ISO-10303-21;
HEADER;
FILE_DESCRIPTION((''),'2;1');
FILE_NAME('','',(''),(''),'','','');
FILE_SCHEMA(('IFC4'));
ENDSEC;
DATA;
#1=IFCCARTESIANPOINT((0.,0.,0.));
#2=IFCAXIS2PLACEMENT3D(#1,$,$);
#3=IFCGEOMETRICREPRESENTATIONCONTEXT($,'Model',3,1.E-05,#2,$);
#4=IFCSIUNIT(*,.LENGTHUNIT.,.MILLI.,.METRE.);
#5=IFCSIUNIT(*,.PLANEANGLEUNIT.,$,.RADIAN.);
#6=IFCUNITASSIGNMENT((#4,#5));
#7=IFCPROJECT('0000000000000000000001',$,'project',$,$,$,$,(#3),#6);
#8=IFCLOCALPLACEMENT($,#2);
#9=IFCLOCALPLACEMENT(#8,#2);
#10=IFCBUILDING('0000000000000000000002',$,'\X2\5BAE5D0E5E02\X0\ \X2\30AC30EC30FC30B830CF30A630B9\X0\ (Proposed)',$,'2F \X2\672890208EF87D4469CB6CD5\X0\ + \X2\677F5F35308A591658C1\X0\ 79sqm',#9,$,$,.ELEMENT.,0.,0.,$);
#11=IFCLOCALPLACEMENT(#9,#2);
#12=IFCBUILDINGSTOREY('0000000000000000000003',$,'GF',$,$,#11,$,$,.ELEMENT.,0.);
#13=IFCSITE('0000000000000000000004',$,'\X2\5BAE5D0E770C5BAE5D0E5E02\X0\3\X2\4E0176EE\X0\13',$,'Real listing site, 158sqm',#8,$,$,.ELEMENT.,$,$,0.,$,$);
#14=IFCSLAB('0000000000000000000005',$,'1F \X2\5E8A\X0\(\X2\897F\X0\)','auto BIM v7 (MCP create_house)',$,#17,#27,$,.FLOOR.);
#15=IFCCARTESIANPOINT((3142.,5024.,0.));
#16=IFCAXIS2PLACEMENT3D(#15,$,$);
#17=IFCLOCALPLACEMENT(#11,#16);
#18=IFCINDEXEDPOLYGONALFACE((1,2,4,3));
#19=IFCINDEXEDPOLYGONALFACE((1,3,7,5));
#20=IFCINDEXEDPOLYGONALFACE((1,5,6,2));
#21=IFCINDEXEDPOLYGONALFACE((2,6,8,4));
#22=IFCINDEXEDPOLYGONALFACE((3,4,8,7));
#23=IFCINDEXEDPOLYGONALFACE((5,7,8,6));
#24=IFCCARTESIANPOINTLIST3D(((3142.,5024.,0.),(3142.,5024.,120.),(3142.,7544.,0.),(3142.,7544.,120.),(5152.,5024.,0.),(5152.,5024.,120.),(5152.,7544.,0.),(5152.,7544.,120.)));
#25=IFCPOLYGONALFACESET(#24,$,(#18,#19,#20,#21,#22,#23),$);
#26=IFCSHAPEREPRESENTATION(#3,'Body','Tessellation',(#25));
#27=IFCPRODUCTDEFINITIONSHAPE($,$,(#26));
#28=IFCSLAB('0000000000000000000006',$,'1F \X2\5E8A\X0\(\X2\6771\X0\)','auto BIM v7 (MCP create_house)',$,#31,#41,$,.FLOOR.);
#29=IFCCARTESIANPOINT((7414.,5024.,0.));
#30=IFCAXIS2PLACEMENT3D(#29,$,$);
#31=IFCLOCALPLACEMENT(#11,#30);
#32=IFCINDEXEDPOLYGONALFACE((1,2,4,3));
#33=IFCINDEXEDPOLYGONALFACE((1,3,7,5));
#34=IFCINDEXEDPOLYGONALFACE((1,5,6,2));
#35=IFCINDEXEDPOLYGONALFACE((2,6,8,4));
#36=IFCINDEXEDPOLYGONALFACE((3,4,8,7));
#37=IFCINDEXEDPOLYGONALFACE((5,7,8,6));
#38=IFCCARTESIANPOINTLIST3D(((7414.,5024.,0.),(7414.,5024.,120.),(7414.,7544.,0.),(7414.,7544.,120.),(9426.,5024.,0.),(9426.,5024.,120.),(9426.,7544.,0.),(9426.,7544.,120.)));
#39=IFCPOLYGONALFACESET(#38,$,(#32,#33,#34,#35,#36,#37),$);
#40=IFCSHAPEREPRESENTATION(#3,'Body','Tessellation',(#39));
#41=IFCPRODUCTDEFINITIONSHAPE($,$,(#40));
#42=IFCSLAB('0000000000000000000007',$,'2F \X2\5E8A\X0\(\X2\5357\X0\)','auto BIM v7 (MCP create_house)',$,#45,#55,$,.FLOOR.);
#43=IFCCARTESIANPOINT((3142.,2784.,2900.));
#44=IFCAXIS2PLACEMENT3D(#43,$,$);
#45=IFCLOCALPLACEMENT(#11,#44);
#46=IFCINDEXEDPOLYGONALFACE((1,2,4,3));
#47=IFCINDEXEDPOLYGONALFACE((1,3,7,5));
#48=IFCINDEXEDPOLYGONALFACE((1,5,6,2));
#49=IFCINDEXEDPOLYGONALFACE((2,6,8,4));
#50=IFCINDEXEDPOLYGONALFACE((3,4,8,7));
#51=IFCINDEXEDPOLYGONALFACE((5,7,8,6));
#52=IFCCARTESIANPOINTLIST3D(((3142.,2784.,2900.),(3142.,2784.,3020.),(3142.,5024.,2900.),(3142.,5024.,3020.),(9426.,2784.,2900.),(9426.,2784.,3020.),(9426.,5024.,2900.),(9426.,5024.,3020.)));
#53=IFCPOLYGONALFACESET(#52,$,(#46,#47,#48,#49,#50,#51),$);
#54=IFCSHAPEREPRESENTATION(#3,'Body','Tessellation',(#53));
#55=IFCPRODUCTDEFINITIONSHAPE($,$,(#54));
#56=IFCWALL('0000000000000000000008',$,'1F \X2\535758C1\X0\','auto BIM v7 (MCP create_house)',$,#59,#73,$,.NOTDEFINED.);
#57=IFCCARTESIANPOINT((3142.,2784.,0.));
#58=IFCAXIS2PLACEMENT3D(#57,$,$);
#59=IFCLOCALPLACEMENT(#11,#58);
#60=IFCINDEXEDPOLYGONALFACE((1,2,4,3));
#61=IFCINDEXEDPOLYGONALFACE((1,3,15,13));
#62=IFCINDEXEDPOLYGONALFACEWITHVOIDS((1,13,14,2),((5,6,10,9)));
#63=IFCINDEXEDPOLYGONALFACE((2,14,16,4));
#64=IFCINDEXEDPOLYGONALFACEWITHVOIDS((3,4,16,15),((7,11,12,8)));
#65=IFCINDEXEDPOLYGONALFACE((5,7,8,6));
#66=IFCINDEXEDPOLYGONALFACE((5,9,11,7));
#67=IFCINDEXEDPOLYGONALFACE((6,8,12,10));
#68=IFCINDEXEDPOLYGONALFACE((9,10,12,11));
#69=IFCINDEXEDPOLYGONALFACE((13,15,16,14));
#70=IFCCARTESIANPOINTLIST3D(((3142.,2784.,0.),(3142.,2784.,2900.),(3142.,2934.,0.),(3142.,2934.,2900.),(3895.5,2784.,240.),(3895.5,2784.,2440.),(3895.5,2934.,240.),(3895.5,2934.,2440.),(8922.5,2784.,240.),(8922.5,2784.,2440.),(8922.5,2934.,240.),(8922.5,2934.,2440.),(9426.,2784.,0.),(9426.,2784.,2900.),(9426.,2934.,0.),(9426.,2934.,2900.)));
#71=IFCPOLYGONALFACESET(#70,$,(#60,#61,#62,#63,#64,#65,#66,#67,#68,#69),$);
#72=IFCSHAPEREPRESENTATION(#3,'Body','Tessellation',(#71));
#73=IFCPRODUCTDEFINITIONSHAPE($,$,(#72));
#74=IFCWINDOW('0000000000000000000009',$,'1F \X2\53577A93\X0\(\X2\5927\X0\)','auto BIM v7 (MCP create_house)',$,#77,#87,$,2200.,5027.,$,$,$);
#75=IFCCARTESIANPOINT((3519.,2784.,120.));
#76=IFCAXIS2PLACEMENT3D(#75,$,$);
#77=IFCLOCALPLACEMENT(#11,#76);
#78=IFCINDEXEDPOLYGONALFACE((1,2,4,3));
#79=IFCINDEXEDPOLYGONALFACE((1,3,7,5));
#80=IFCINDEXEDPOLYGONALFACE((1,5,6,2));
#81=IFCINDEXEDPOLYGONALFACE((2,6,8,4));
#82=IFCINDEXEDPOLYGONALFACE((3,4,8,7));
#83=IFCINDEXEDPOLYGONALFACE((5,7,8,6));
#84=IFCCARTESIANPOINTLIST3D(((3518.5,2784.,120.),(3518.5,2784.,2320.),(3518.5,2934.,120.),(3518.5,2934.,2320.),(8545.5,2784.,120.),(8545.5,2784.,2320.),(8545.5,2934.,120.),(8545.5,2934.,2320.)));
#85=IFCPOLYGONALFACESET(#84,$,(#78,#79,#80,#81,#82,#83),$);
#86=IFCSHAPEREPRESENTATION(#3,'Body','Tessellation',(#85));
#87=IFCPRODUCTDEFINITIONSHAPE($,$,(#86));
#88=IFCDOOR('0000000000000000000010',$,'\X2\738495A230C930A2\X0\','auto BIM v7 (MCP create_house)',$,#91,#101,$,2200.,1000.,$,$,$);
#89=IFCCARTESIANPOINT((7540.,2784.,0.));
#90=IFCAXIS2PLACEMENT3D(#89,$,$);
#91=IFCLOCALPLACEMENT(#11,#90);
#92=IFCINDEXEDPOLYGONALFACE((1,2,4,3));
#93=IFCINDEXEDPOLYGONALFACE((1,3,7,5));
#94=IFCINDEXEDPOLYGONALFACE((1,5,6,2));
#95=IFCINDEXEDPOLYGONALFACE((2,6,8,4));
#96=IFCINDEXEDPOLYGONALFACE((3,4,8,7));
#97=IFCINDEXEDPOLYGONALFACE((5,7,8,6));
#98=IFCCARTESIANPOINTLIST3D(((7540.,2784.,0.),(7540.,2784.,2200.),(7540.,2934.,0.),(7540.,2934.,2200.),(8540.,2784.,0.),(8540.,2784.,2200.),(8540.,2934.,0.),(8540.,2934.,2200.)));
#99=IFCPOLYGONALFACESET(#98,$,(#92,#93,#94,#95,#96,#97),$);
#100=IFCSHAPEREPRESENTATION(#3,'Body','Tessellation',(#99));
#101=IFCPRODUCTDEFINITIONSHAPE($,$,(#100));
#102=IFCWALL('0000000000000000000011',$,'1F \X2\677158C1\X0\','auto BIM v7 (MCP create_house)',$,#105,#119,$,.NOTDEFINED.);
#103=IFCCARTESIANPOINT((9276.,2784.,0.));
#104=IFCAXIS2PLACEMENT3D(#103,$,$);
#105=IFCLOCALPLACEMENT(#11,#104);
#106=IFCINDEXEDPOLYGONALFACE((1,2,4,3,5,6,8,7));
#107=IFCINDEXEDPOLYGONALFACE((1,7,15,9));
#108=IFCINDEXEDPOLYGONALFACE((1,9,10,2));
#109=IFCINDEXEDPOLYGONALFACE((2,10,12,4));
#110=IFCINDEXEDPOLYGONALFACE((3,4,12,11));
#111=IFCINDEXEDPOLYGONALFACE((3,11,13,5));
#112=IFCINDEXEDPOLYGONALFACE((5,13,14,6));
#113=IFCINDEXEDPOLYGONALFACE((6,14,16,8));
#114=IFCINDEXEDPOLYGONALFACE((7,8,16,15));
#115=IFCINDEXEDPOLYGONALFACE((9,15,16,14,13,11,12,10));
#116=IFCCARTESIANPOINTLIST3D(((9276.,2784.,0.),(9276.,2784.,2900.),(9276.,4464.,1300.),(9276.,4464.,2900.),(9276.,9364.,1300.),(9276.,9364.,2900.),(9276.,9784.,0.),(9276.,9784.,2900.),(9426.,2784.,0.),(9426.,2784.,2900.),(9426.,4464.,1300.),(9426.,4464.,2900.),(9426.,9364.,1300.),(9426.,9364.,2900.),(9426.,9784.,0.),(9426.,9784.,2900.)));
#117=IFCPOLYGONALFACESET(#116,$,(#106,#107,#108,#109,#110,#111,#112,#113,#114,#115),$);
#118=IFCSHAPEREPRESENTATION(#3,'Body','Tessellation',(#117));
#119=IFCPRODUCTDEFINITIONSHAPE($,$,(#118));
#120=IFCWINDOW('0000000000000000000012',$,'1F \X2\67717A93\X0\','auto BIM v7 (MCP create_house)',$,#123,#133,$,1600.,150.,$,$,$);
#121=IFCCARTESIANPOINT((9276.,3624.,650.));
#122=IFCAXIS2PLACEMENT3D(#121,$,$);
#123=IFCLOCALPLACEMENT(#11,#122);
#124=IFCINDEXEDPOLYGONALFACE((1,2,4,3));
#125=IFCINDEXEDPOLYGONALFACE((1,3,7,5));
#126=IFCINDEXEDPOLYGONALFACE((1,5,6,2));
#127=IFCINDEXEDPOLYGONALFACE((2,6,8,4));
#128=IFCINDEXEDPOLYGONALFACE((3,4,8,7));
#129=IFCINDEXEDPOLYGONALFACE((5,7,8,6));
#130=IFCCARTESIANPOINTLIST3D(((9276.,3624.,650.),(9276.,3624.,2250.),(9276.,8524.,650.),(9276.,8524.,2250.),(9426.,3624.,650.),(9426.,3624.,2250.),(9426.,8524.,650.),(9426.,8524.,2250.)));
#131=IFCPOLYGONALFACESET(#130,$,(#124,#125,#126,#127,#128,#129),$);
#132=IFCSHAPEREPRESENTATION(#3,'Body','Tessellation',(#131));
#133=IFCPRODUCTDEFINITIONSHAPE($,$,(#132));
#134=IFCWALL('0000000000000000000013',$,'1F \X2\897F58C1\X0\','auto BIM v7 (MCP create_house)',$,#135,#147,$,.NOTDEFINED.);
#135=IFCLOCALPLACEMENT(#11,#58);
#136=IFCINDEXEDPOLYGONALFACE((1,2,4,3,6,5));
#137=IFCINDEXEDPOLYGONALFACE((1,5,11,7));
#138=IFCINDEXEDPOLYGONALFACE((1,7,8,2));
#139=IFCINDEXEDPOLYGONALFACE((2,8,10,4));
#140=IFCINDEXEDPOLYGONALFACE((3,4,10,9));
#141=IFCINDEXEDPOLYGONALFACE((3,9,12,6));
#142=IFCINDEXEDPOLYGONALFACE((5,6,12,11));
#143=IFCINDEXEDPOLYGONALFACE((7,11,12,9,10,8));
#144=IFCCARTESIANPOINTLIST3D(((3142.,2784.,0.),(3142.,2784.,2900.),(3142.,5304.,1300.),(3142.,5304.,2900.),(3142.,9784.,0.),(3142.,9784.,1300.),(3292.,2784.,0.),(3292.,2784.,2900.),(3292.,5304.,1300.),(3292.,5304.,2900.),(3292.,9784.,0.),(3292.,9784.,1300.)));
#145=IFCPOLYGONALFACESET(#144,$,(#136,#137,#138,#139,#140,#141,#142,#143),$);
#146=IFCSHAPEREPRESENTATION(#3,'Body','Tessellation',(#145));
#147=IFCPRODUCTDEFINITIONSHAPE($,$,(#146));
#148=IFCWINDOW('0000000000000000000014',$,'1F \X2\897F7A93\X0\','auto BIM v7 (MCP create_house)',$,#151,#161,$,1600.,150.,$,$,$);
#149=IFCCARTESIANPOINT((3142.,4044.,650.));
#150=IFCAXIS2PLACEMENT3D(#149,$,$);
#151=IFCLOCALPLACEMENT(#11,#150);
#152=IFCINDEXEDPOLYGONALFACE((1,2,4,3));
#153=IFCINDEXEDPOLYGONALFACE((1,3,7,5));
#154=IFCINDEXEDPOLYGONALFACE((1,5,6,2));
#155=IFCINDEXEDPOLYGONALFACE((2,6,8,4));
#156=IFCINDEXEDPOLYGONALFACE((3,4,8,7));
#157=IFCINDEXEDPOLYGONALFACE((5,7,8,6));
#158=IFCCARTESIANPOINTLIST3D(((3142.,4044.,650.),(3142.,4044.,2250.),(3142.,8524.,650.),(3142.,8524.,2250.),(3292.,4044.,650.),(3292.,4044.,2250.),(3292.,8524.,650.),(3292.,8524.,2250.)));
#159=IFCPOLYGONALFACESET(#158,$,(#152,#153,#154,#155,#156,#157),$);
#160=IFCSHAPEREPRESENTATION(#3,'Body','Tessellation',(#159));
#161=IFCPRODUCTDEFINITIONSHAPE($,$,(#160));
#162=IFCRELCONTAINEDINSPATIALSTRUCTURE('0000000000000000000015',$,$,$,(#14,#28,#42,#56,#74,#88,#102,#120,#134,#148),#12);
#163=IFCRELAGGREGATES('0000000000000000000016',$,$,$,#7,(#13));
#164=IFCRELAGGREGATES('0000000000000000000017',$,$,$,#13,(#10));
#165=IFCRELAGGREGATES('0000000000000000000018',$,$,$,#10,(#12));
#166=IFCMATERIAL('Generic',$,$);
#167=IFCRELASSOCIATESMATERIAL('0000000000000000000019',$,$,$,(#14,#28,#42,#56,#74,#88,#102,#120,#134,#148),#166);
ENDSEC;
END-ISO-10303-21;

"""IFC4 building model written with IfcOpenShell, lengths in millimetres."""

from ifc_helpers import new_model, si_unit, frame, frame_2d, origin, place, context, project, spatial, rectangle, extrude, material, element, fill, save


model = new_model("IFC4")

# Units and contexts
model_context = context("Model", 3, precision=1e-05, world=origin())
ifc_project = project(units=[si_unit("LENGTHUNIT", "METRE", prefix="MILLI"), si_unit("PLANEANGLEUNIT", "RADIAN")], contexts=[model_context])

# Site, building, storey
site_placement = place(None, origin())
site = spatial("IfcSite", under=ifc_project, at=site_placement, Name="宮崎県宮崎市3丁目13", ObjectType="Real listing site, 158sqm", CompositionType="ELEMENT", RefElevation=0.0)
building_placement = place(site_placement, origin())
building = spatial("IfcBuilding", under=site, at=building_placement, Name="宮崎市 ガレージハウス (Proposed)", ObjectType="2F 木造軸組構法 + 板張り外壁 79sqm", CompositionType="ELEMENT", ElevationOfRefHeight=0.0, ElevationOfTerrain=0.0)
storey_placement = place(building_placement, origin())
storey = spatial("IfcBuildingStorey", under=building, at=storey_placement, Name="GF", CompositionType="ELEMENT", Elevation=0.0)

# Slabs
ifc_material = material(Name="Generic")
slab_1_placement = place(storey_placement, frame((3142.0, 5024.0, 0.0)))
element("IfcSlab", 1, at=slab_1_placement, inside=storey, material=ifc_material, Name="1F 床(西)", Description="auto BIM v7 (MCP create_house)", PredefinedType="FLOOR", context=model_context, shape_type="SweptSolid", body=[
    extrude(rectangle(XDim=2010.0, YDim=2520.0, at=frame_2d((1005.0, 1260.0))), frame((3142.0, 5024.0, 0.0)), (0.0, 0.0, 1.0), 120.0),
])
slab_2_placement = place(storey_placement, frame((7414.0, 5024.0, 0.0)))
element("IfcSlab", 2, at=slab_2_placement, inside=storey, material=ifc_material, Name="1F 床(東)", Description="auto BIM v7 (MCP create_house)", PredefinedType="FLOOR", context=model_context, shape_type="SweptSolid", body=[
    extrude(rectangle(XDim=2012.0, YDim=2520.0, at=frame_2d((1006.0, 1260.0))), frame((7414.0, 5024.0, 0.0)), (0.0, 0.0, 1.0), 120.0),
])
slab_3_placement = place(storey_placement, frame((3142.0, 2784.0, 2900.0)))
element("IfcSlab", 3, at=slab_3_placement, inside=storey, material=ifc_material, Name="2F 床(南)", Description="auto BIM v7 (MCP create_house)", PredefinedType="FLOOR", context=model_context, shape_type="SweptSolid", body=[
    extrude(rectangle(XDim=6284.0, YDim=2240.0, at=frame_2d((3142.0, 1120.0))), frame((3142.0, 2784.0, 2900.0)), (0.0, 0.0, 1.0), 120.0),
])

# Wall, openings, window, door
wall_1_placement = place(storey_placement, frame((3142.0, 2784.0, 0.0)))
wall_1 = element("IfcWall", 4, at=wall_1_placement, inside=storey, material=ifc_material, Name="1F 南壁", Description="auto BIM v7 (MCP create_house)", PredefinedType="NOTDEFINED", context=model_context, shape_type="SweptSolid", body=[
    extrude(rectangle(XDim=6284.0, YDim=150.0, at=frame_2d((3142.0, 75.0))), frame((3142.0, 2784.0, 0.0)), (0.0, 0.0, 1.0), 2900.0),
])
opening_1_placement = place(storey_placement, frame((3519.0, 2784.0, 120.0)))
opening_1 = element("IfcOpeningElement", 5, at=opening_1_placement, cuts=wall_1, PredefinedType="NOTDEFINED", context=model_context, shape_type="SweptSolid", body=[
    extrude(rectangle(XDim=5027.0, YDim=150.0, at=frame_2d((2513.0, 75.0))), frame((3519.0, 2784.0, 120.0)), (0.0, 0.0, 1.0), 2200.0),
])
opening_2_placement = place(storey_placement, frame((7540.0, 2784.0, 0.0)))
opening_2 = element("IfcOpeningElement", 6, at=opening_2_placement, cuts=wall_1, PredefinedType="NOTDEFINED", context=model_context, shape_type="SweptSolid", body=[
    extrude(rectangle(XDim=1000.0, YDim=150.0, at=frame_2d((500.0, 75.0))), frame((7540.0, 2784.0, 0.0)), (0.0, 0.0, 1.0), 2200.0),
])
window_1_placement = place(storey_placement, frame((3519.0, 2784.0, 120.0)))
window_1 = element("IfcWindow", 7, at=window_1_placement, inside=storey, material=ifc_material, Name="1F 南窓(大)", Description="auto BIM v7 (MCP create_house)", OverallHeight=2200.0, OverallWidth=5027.0, context=model_context, shape_type="SweptSolid", body=[
    extrude(rectangle(XDim=5027.0, YDim=150.0, at=frame_2d((2513.0, 75.0))), frame((3519.0, 2784.0, 120.0)), (0.0, 0.0, 1.0), 2200.0),
])
fill(opening_1, window_1)
door_placement = place(storey_placement, frame((7540.0, 2784.0, 0.0)))
door = element("IfcDoor", 8, at=door_placement, inside=storey, material=ifc_material, Name="玄関ドア", Description="auto BIM v7 (MCP create_house)", OverallHeight=2200.0, OverallWidth=1000.0, context=model_context, shape_type="SweptSolid", body=[
    extrude(rectangle(XDim=1000.0, YDim=150.0, at=frame_2d((500.0, 75.0))), frame((7540.0, 2784.0, 0.0)), (0.0, 0.0, 1.0), 2200.0),
])
fill(opening_2, door)

# Walls, openings, windows
wall_2_placement = place(storey_placement, frame((9276.0, 2784.0, 0.0)))
wall_2 = element("IfcWall", 9, at=wall_2_placement, inside=storey, material=ifc_material, Name="1F 東壁", Description="auto BIM v7 (MCP create_house)", PredefinedType="NOTDEFINED", context=model_context, shape_type="SweptSolid", body=[
    extrude(rectangle(XDim=150.0, YDim=7000.0, at=frame_2d((75.0, 3500.0))), frame((9276.0, 2784.0, 0.0)), (0.0, 0.0, 1.0), 2900.0),
])
opening_3_placement = place(storey_placement, frame((9276.0, 3624.0, 650.0)))
opening_3 = element("IfcOpeningElement", 10, at=opening_3_placement, cuts=wall_2, PredefinedType="NOTDEFINED", context=model_context, shape_type="SweptSolid", body=[
    extrude(rectangle(XDim=150.0, YDim=4900.0, at=frame_2d((75.0, 2450.0))), frame((9276.0, 3624.0, 650.0)), (0.0, 0.0, 1.0), 1600.0),
])
window_2_placement = place(storey_placement, frame((9276.0, 3624.0, 650.0)))
window_2 = element("IfcWindow", 11, at=window_2_placement, inside=storey, material=ifc_material, Name="1F 東窓", Description="auto BIM v7 (MCP create_house)", OverallHeight=1600.0, OverallWidth=150.0, context=model_context, shape_type="SweptSolid", body=[
    extrude(rectangle(XDim=150.0, YDim=4900.0, at=frame_2d((75.0, 2450.0))), frame((9276.0, 3624.0, 650.0)), (0.0, 0.0, 1.0), 1600.0),
])
fill(opening_3, window_2)
wall_3_placement = place(storey_placement, frame((3142.0, 2784.0, 0.0)))
wall_3 = element("IfcWall", 12, at=wall_3_placement, inside=storey, material=ifc_material, Name="1F 西壁", Description="auto BIM v7 (MCP create_house)", PredefinedType="NOTDEFINED", context=model_context, shape_type="SweptSolid", body=[
    extrude(rectangle(XDim=150.0, YDim=7000.0, at=frame_2d((75.0, 3500.0))), frame((3142.0, 2784.0, 0.0)), (0.0, 0.0, 1.0), 2900.0),
])
opening_4_placement = place(storey_placement, frame((3142.0, 4044.0, 650.0)))
opening_4 = element("IfcOpeningElement", 13, at=opening_4_placement, cuts=wall_3, PredefinedType="NOTDEFINED", context=model_context, shape_type="SweptSolid", body=[
    extrude(rectangle(XDim=150.0, YDim=4480.0, at=frame_2d((75.0, 2240.0))), frame((3142.0, 4044.0, 650.0)), (0.0, 0.0, 1.0), 1600.0),
])
window_3_placement = place(storey_placement, frame((3142.0, 4044.0, 650.0)))
window_3 = element("IfcWindow", 14, at=window_3_placement, inside=storey, material=ifc_material, Name="1F 西窓", Description="auto BIM v7 (MCP create_house)", OverallHeight=1600.0, OverallWidth=150.0, context=model_context, shape_type="SweptSolid", body=[
    extrude(rectangle(XDim=150.0, YDim=4480.0, at=frame_2d((75.0, 2240.0))), frame((3142.0, 4044.0, 650.0)), (0.0, 0.0, 1.0), 1600.0),
])
fill(opening_4, window_3)

save(model, "model.ifc")
